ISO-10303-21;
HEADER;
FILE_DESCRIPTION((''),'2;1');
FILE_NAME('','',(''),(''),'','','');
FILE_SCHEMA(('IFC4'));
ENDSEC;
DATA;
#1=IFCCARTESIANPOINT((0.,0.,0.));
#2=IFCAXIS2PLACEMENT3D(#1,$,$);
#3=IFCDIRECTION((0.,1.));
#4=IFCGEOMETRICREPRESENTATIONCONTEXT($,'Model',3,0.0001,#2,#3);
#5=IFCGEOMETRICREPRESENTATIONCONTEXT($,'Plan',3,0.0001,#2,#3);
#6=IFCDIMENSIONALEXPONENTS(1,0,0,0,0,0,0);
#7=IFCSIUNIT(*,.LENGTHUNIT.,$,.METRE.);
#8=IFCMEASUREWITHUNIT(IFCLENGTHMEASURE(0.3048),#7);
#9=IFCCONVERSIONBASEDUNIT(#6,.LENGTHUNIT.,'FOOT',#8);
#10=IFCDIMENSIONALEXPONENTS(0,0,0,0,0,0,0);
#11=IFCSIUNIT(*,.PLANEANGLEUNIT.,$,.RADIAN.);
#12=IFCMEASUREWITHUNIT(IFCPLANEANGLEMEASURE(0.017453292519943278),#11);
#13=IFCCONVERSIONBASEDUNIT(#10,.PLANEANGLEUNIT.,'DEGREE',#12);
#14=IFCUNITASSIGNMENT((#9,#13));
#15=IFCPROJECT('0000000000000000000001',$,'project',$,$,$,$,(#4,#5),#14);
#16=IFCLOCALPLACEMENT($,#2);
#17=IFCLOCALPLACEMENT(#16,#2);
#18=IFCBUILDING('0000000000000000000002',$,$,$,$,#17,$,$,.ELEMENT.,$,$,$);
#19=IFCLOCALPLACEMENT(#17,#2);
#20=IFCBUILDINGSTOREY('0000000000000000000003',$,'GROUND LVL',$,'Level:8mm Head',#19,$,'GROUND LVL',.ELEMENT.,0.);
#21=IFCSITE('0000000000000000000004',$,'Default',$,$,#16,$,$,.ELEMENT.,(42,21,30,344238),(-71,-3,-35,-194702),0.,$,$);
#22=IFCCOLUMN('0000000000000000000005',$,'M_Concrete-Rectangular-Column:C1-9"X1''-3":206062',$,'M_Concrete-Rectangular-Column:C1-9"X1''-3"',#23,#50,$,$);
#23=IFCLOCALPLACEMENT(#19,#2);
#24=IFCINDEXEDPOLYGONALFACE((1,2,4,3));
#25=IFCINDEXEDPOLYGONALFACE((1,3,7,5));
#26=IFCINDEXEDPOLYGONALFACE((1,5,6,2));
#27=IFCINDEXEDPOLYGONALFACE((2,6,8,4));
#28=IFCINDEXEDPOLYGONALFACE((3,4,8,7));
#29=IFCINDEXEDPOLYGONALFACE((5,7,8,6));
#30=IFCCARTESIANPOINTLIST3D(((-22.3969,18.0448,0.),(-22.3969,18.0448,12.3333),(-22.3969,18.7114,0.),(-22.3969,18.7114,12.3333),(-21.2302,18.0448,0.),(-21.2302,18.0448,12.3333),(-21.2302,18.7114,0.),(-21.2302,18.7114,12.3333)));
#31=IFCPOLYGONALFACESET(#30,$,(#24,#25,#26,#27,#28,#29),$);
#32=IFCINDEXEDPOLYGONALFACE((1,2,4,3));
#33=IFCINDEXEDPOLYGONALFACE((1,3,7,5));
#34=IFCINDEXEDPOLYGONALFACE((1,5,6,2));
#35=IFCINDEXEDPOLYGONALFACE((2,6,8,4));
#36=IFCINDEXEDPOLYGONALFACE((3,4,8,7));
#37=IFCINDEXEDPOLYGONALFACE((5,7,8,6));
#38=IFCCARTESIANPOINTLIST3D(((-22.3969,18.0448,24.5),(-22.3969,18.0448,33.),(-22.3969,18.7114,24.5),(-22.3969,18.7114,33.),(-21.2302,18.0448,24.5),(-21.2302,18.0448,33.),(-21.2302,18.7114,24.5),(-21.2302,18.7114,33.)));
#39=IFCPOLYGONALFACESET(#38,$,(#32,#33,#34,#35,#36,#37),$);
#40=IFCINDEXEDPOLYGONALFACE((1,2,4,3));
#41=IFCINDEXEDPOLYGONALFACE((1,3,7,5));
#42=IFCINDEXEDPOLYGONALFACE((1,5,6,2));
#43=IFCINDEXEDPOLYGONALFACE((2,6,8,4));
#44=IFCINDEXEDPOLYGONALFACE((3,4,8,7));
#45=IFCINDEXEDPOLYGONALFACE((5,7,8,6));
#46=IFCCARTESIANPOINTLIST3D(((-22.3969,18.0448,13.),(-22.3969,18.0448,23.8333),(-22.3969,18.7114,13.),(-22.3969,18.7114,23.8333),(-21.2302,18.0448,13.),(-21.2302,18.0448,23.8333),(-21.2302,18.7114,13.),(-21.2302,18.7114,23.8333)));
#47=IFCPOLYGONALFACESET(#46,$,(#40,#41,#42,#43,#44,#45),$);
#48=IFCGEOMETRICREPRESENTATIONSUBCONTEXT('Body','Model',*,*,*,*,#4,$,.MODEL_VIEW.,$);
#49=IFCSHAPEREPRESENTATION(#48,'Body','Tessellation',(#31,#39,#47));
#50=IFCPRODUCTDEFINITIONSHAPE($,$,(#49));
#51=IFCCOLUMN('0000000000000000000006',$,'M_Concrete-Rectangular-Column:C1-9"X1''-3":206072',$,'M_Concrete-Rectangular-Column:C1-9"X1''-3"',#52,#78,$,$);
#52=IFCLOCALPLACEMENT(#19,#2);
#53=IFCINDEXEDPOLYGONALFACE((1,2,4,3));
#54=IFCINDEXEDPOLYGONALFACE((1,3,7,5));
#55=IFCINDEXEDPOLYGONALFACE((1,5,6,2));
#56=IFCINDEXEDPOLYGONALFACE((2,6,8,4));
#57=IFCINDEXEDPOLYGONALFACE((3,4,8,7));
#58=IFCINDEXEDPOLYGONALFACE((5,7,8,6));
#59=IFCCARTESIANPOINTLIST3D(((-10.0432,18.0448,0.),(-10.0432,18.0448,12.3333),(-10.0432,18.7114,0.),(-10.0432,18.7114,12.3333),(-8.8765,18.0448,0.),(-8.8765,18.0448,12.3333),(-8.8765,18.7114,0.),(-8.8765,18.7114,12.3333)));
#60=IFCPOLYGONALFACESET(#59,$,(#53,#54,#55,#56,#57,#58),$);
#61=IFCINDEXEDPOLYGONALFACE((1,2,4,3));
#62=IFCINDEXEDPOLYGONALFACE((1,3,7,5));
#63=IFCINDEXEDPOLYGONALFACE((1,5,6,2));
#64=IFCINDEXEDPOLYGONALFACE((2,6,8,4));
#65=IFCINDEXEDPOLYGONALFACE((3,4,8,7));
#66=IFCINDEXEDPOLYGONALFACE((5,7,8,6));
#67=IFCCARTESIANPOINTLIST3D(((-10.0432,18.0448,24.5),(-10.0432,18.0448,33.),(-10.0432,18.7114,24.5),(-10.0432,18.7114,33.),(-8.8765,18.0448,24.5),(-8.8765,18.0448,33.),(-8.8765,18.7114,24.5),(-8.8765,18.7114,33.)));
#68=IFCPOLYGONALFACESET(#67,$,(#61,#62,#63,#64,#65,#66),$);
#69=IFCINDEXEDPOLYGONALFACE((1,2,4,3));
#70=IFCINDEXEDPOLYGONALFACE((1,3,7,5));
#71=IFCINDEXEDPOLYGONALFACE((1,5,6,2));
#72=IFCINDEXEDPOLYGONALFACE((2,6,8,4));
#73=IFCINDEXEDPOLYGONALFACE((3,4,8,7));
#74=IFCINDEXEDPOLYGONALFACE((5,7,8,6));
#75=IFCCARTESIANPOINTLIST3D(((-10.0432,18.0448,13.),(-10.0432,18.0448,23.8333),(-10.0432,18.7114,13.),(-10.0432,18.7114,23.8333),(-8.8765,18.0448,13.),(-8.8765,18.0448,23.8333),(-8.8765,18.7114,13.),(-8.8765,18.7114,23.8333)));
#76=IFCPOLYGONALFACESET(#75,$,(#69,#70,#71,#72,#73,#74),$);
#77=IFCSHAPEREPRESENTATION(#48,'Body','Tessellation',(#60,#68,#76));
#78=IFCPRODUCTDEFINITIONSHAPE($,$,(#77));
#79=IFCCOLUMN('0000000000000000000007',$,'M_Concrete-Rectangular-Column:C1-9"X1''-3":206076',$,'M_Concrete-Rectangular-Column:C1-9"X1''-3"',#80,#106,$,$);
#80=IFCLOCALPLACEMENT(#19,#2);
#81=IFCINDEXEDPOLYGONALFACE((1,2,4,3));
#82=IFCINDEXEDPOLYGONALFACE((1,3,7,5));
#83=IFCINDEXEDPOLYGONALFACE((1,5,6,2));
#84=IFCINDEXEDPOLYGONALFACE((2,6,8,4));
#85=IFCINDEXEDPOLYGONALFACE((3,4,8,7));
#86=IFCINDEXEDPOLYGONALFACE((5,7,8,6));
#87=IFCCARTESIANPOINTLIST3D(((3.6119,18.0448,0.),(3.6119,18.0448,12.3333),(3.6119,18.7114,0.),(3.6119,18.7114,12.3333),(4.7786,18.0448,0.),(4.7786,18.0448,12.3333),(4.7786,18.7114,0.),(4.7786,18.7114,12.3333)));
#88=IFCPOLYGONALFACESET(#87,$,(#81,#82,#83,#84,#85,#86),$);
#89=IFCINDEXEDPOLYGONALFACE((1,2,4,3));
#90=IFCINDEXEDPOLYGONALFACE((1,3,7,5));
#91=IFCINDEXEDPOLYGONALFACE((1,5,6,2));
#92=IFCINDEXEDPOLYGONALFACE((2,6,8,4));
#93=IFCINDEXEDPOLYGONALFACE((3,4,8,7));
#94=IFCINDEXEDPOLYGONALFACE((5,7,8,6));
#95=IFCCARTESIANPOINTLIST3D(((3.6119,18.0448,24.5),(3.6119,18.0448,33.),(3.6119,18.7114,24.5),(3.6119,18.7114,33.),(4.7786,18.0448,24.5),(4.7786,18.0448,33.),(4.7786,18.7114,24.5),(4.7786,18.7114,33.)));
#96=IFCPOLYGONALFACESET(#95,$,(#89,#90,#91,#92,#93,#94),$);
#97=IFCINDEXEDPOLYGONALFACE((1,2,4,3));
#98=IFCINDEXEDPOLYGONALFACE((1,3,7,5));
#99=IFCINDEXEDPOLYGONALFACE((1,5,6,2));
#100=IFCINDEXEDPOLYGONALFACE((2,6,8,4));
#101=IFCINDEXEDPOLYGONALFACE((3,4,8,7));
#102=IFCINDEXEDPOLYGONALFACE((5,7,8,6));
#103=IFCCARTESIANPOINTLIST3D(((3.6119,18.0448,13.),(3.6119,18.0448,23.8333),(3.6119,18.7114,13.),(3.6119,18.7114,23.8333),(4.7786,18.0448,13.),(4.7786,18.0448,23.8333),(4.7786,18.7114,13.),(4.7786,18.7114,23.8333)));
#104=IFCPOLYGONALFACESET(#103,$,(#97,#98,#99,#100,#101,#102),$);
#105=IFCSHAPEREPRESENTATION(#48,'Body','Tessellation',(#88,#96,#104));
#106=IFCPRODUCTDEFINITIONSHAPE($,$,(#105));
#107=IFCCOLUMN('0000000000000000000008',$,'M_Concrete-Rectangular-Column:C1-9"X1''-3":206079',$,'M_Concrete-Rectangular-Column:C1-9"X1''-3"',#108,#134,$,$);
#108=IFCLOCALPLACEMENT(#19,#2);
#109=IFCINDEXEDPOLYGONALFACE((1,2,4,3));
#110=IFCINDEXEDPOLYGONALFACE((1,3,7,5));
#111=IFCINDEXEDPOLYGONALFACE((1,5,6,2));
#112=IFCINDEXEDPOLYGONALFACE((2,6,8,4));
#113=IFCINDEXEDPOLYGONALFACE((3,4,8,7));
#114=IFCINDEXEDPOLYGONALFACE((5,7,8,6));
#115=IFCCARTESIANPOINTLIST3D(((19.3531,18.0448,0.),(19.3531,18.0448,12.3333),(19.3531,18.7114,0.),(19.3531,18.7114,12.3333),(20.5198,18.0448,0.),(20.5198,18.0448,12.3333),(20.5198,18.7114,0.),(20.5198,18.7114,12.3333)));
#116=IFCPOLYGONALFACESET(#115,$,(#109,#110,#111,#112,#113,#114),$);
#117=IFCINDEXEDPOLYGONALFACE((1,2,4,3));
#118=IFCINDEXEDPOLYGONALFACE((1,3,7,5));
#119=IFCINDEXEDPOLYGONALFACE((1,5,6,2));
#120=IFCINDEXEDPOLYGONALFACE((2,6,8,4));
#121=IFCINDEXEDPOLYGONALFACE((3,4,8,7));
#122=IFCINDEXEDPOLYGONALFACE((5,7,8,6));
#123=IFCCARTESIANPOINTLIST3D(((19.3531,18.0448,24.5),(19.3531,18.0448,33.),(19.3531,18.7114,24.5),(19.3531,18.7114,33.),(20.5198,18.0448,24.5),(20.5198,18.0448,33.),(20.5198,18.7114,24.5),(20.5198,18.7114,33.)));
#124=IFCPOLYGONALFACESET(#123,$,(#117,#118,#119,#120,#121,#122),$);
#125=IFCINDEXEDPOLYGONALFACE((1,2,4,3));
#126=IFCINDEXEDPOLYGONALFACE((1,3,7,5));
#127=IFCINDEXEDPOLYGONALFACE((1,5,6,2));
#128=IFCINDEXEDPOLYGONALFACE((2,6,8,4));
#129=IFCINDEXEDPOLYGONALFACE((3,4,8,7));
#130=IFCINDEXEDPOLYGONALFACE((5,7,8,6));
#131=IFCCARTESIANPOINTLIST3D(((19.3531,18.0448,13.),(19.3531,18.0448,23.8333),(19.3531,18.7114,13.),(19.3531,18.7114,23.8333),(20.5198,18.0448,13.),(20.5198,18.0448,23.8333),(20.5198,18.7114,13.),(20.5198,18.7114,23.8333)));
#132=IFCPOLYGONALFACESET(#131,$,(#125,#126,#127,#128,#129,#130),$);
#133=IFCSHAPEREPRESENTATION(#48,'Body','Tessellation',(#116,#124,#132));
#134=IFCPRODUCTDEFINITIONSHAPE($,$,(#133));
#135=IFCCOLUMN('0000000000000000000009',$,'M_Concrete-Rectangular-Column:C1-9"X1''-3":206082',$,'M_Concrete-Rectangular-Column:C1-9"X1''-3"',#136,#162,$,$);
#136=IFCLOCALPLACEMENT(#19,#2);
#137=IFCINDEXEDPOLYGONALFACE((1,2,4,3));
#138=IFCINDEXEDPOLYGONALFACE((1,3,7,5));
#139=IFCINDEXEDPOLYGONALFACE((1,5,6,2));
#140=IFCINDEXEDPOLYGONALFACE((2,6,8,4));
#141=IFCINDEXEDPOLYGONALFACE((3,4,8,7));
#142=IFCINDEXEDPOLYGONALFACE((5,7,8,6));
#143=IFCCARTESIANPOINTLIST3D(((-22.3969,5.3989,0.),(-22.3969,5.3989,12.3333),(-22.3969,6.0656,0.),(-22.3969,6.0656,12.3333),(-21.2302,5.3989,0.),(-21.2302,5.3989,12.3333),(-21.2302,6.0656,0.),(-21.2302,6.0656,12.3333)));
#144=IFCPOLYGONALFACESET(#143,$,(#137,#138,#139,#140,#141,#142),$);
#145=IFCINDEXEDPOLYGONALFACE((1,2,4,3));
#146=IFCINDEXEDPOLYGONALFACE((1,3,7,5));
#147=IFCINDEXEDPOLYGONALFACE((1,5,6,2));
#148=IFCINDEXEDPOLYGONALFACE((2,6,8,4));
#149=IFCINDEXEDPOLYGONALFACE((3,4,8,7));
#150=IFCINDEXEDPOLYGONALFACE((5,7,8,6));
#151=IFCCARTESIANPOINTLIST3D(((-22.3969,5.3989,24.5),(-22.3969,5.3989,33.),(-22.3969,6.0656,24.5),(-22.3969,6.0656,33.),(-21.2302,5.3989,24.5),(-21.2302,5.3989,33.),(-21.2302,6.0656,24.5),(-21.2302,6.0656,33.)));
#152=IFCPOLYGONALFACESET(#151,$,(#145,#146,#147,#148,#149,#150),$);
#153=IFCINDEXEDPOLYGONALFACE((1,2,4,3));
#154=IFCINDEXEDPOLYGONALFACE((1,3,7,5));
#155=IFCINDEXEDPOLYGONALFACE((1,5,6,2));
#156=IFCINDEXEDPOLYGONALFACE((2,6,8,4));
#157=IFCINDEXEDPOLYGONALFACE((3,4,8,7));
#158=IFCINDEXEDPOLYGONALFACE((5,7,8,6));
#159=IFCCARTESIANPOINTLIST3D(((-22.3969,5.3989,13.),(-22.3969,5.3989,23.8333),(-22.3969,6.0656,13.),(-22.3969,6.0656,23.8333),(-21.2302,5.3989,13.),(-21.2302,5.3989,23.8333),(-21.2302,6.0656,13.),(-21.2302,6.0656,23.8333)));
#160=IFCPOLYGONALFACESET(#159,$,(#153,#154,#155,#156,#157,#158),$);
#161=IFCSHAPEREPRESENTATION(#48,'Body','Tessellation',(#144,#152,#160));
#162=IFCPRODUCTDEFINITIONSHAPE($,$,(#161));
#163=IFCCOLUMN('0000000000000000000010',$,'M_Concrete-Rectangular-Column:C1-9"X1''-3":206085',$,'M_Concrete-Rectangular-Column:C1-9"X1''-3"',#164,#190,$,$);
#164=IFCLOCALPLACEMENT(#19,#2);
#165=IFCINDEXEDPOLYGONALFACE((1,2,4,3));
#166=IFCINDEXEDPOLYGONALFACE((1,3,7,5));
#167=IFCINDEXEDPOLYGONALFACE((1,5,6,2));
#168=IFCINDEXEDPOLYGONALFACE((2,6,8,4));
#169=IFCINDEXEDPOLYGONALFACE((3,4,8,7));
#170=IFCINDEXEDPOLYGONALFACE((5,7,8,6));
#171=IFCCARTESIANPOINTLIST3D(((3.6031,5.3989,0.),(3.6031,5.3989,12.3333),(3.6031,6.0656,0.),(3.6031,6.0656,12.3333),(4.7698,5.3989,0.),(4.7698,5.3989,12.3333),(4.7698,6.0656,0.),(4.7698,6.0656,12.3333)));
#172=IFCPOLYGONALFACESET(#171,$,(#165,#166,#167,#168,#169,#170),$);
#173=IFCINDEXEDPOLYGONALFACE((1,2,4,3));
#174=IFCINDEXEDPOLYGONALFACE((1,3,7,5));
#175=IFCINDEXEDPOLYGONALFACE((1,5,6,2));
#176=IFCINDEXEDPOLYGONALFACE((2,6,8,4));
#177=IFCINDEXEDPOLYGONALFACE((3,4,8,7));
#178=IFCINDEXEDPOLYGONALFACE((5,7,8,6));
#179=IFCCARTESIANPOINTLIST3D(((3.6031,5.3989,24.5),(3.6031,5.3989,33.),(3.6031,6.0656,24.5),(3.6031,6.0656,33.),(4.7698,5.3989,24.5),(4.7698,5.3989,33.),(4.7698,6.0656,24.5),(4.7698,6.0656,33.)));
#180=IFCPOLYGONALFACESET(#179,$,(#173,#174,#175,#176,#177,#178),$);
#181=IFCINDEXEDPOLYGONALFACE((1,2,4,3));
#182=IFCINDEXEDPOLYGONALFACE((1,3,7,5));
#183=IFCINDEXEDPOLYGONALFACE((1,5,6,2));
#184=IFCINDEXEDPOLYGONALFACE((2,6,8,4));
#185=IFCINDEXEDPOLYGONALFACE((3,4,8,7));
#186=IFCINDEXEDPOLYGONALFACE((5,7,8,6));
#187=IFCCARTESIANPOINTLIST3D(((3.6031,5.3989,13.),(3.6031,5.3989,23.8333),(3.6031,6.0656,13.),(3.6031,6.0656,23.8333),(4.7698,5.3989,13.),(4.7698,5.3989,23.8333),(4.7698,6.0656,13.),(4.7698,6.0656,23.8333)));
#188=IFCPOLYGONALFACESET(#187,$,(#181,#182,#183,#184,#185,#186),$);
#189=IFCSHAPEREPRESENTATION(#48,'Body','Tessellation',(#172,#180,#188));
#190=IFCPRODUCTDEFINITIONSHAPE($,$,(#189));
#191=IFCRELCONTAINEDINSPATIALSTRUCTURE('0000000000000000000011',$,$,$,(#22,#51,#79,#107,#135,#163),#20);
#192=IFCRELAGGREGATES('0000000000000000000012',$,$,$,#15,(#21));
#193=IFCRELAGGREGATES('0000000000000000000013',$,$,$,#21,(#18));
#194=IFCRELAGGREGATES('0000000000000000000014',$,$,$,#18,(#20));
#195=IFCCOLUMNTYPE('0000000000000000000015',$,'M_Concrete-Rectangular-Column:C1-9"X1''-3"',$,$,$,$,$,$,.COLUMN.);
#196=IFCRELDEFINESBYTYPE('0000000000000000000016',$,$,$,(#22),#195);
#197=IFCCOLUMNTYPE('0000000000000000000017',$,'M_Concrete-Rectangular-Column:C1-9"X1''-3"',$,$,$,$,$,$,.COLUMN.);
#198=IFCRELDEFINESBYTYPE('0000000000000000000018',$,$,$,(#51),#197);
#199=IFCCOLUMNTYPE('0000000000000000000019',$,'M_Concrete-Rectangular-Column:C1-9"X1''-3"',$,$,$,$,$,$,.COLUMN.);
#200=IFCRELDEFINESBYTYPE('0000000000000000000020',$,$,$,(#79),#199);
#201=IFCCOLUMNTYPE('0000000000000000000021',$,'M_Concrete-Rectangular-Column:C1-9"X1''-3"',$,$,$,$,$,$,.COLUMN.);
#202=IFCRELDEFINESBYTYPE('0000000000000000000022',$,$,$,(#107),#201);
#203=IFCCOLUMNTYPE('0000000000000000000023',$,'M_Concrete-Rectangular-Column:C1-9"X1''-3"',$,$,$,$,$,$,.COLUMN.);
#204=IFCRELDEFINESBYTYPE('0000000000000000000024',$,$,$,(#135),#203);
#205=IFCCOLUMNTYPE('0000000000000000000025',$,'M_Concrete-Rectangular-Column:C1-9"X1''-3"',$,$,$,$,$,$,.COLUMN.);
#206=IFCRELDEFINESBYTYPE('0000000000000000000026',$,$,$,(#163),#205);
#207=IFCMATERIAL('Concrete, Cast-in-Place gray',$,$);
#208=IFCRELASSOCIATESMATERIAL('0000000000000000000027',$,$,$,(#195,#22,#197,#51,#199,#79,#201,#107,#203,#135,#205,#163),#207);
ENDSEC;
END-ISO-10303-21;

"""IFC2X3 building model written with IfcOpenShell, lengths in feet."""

from ifc_helpers import new_model, entity, si_unit, converted_unit, direction, frame, frame_2d, origin, origin_2d_with_axis, place, context, subcontext, project, spatial, rectangle, extrude, source, transform, mapped, material, type_object, type_shapes, element, save


model = new_model("IFC2X3")

# Units and contexts
model_context = context("Model", 3, precision=0.0001, world=origin(), true_north=direction((0.0, 1.0)))
plan_context = context("Plan", 3, precision=0.0001, world=origin(), true_north=direction((0.0, 1.0)))
body_context = subcontext(model_context, "Body", "Model", "MODEL_VIEW")
ifc_project = project(units=[converted_unit("LENGTHUNIT", "FOOT", entity("IfcLengthMeasure", 0.3048), si_unit("LENGTHUNIT", "METRE"), dimensions=[1, 0, 0, 0, 0, 0, 0]), converted_unit("PLANEANGLEUNIT", "DEGREE", entity("IfcPlaneAngleMeasure", 0.017453292519943278), si_unit("PLANEANGLEUNIT", "RADIAN"), dimensions=[0, 0, 0, 0, 0, 0, 0])], contexts=[model_context, plan_context])

# Site, building, storey
site_placement = place(None, origin())
site = spatial("IfcSite", under=ifc_project, at=site_placement, Name="Default", CompositionType="ELEMENT", RefLatitude=(42, 21, 30, 344238), RefLongitude=(-71, -3, -35, -194702), RefElevation=0.0)
building_placement = place(site_placement, origin())
building = spatial("IfcBuilding", under=site, at=building_placement, CompositionType="ELEMENT")
storey_placement = place(building_placement, origin())
storey = spatial("IfcBuildingStorey", under=building, at=storey_placement, Name="GROUND LVL", ObjectType="Level:8mm Head", LongName="GROUND LVL", CompositionType="ELEMENT", Elevation=0.0)

# Columns
ifc_material_1 = material(Name="Concrete, Cast-in-Place gray")
column_type_1 = type_object("IfcColumnType", Name="M_Concrete-Rectangular-Column:C1-9\"X1'-3\"", PredefinedType="COLUMN", material=ifc_material_1)
shared_shape_1 = source(origin(), body_context, "Body", "SweptSolid", [
    extrude(rectangle(XDim=0.6667, YDim=1.1667, at=frame_2d((0.0, 0.0), x_axis=(1.0, 0.0))), frame((-21.8136, 18.3781, 0.0), z_axis=(0.0, 0.0, 1.0), x_axis=(0.0, -1.0, 0.0)), (0.0, 0.0, 1.0), 12.3333),
    extrude(rectangle(XDim=0.6667, YDim=1.1667, at=origin_2d_with_axis()), frame((-21.8136, 18.3781, 24.5), z_axis=(0.0, 0.0, 1.0), x_axis=(0.0, -1.0, 0.0)), (0.0, 0.0, 1.0), 8.5),
    extrude(rectangle(XDim=0.6667, YDim=1.1667, at=origin_2d_with_axis()), frame((-21.8136, 18.3781, 13.0), z_axis=(0.0, 0.0, 1.0), x_axis=(0.0, -1.0, 0.0)), (0.0, 0.0, 1.0), 10.8333),
])
type_shapes(column_type_1, [shared_shape_1])
column_1_placement = place(storey_placement, origin())
element("IfcColumn", 1, at=column_1_placement, inside=storey, type_object=column_type_1, material=ifc_material_1, Name="M_Concrete-Rectangular-Column:C1-9\"X1'-3\":206062", ObjectType="M_Concrete-Rectangular-Column:C1-9\"X1'-3\"", context=body_context, shape_type="MappedRepresentation", body=[
    mapped(shared_shape_1, transform((0.0, 0.0, 0.0), scale=1.0)),
])
column_type_2 = type_object("IfcColumnType", Name="M_Concrete-Rectangular-Column:C1-9\"X1'-3\"", PredefinedType="COLUMN", material=ifc_material_1)
shared_shape_2 = source(origin(), body_context, "Body", "SweptSolid", [
    extrude(rectangle(XDim=0.6667, YDim=1.1667, at=frame_2d((0.0, 0.0), x_axis=(1.0, 0.0))), frame((-9.4598, 18.3781, 0.0), z_axis=(0.0, 0.0, 1.0), x_axis=(0.0, -1.0, 0.0)), (0.0, 0.0, 1.0), 12.3333),
    extrude(rectangle(XDim=0.6667, YDim=1.1667, at=origin_2d_with_axis()), frame((-9.4598, 18.3781, 24.5), z_axis=(0.0, 0.0, 1.0), x_axis=(0.0, -1.0, 0.0)), (0.0, 0.0, 1.0), 8.5),
    extrude(rectangle(XDim=0.6667, YDim=1.1667, at=origin_2d_with_axis()), frame((-9.4598, 18.3781, 13.0), z_axis=(0.0, 0.0, 1.0), x_axis=(0.0, -1.0, 0.0)), (0.0, 0.0, 1.0), 10.8333),
])
type_shapes(column_type_2, [shared_shape_2])
column_2_placement = place(storey_placement, origin())
element("IfcColumn", 2, at=column_2_placement, inside=storey, type_object=column_type_2, material=ifc_material_1, Name="M_Concrete-Rectangular-Column:C1-9\"X1'-3\":206072", ObjectType="M_Concrete-Rectangular-Column:C1-9\"X1'-3\"", context=body_context, shape_type="MappedRepresentation", body=[
    mapped(shared_shape_2, transform((0.0, 0.0, 0.0), scale=1.0)),
])
column_type_3 = type_object("IfcColumnType", Name="M_Concrete-Rectangular-Column:C1-9\"X1'-3\"", PredefinedType="COLUMN", material=ifc_material_1)
shared_shape_3 = source(origin(), body_context, "Body", "SweptSolid", [
    extrude(rectangle(XDim=0.6667, YDim=1.1667, at=frame_2d((0.0, 0.0), x_axis=(1.0, 0.0))), frame((4.1952, 18.3781, 0.0), z_axis=(0.0, 0.0, 1.0), x_axis=(0.0, -1.0, 0.0)), (0.0, 0.0, 1.0), 12.3333),
    extrude(rectangle(XDim=0.6667, YDim=1.1667, at=frame_2d((0.0, 0.0), x_axis=(1.0, 0.0))), frame((4.1952, 18.3781, 24.5), z_axis=(0.0, 0.0, 1.0), x_axis=(0.0, -1.0, 0.0)), (0.0, 0.0, 1.0), 8.5),
    extrude(rectangle(XDim=0.6667, YDim=1.1667, at=frame_2d((0.0, 0.0), x_axis=(1.0, 0.0))), frame((4.1952, 18.3781, 13.0), z_axis=(0.0, 0.0, 1.0), x_axis=(0.0, -1.0, 0.0)), (0.0, 0.0, 1.0), 10.8333),
])
type_shapes(column_type_3, [shared_shape_3])
column_3_placement = place(storey_placement, origin())
element("IfcColumn", 3, at=column_3_placement, inside=storey, type_object=column_type_3, material=ifc_material_1, Name="M_Concrete-Rectangular-Column:C1-9\"X1'-3\":206076", ObjectType="M_Concrete-Rectangular-Column:C1-9\"X1'-3\"", context=body_context, shape_type="MappedRepresentation", body=[
    mapped(shared_shape_3, transform((0.0, 0.0, 0.0), scale=1.0)),
])
column_type_4 = type_object("IfcColumnType", Name="M_Concrete-Rectangular-Column:C1-9\"X1'-3\"", PredefinedType="COLUMN", material=ifc_material_1)
shared_shape_4 = source(origin(), body_context, "Body", "SweptSolid", [
    extrude(rectangle(XDim=0.6667, YDim=1.1667, at=frame_2d((0.0, 0.0), x_axis=(1.0, 0.0))), frame((19.9364, 18.3781, 0.0), z_axis=(0.0, 0.0, 1.0), x_axis=(0.0, -1.0, 0.0)), (0.0, 0.0, 1.0), 12.3333),
    extrude(rectangle(XDim=0.6667, YDim=1.1667, at=origin_2d_with_axis()), frame((19.9364, 18.3781, 24.5), z_axis=(0.0, 0.0, 1.0), x_axis=(0.0, -1.0, 0.0)), (0.0, 0.0, 1.0), 8.5),
    extrude(rectangle(XDim=0.6667, YDim=1.1667, at=origin_2d_with_axis()), frame((19.9364, 18.3781, 13.0), z_axis=(0.0, 0.0, 1.0), x_axis=(0.0, -1.0, 0.0)), (0.0, 0.0, 1.0), 10.8333),
])
type_shapes(column_type_4, [shared_shape_4])
column_4_placement = place(storey_placement, origin())
element("IfcColumn", 4, at=column_4_placement, inside=storey, type_object=column_type_4, material=ifc_material_1, Name="M_Concrete-Rectangular-Column:C1-9\"X1'-3\":206079", ObjectType="M_Concrete-Rectangular-Column:C1-9\"X1'-3\"", context=body_context, shape_type="MappedRepresentation", body=[
    mapped(shared_shape_4, transform((0.0, 0.0, 0.0), scale=1.0)),
])
column_type_5 = type_object("IfcColumnType", Name="M_Concrete-Rectangular-Column:C1-9\"X1'-3\"", PredefinedType="COLUMN", material=ifc_material_1)
shared_shape_5 = source(origin(), body_context, "Body", "SweptSolid", [
    extrude(rectangle(XDim=0.6667, YDim=1.1667, at=frame_2d((0.0, 0.0), x_axis=(1.0, 0.0))), frame((-21.8136, 5.7323, 0.0), z_axis=(0.0, 0.0, 1.0), x_axis=(0.0, -1.0, 0.0)), (0.0, 0.0, 1.0), 12.3333),
    extrude(rectangle(XDim=0.6667, YDim=1.1667, at=frame_2d((0.0, 0.0), x_axis=(1.0, 0.0))), frame((-21.8136, 5.7323, 24.5), z_axis=(0.0, 0.0, 1.0), x_axis=(0.0, -1.0, 0.0)), (0.0, 0.0, 1.0), 8.5),
    extrude(rectangle(XDim=0.6667, YDim=1.1667, at=frame_2d((0.0, 0.0), x_axis=(1.0, 0.0))), frame((-21.8136, 5.7323, 13.0), z_axis=(0.0, 0.0, 1.0), x_axis=(0.0, -1.0, 0.0)), (0.0, 0.0, 1.0), 10.8333),
])
type_shapes(column_type_5, [shared_shape_5])
column_5_placement = place(storey_placement, origin())
element("IfcColumn", 5, at=column_5_placement, inside=storey, type_object=column_type_5, material=ifc_material_1, Name="M_Concrete-Rectangular-Column:C1-9\"X1'-3\":206082", ObjectType="M_Concrete-Rectangular-Column:C1-9\"X1'-3\"", context=body_context, shape_type="MappedRepresentation", body=[
    mapped(shared_shape_5, transform((0.0, 0.0, 0.0), scale=1.0)),
])
column_type_6 = type_object("IfcColumnType", Name="M_Concrete-Rectangular-Column:C1-9\"X1'-3\"", PredefinedType="COLUMN", material=ifc_material_1)
shared_shape_6 = source(origin(), body_context, "Body", "SweptSolid", [
    extrude(rectangle(XDim=0.6667, YDim=1.1667, at=frame_2d((0.0, 0.0), x_axis=(1.0, 0.0))), frame((4.1864, 5.7323, 0.0), z_axis=(0.0, 0.0, 1.0), x_axis=(0.0, -1.0, 0.0)), (0.0, 0.0, 1.0), 12.3333),
    extrude(rectangle(XDim=0.6667, YDim=1.1667, at=frame_2d((0.0, 0.0), x_axis=(1.0, 0.0))), frame((4.1864, 5.7323, 24.5), z_axis=(0.0, 0.0, 1.0), x_axis=(0.0, -1.0, 0.0)), (0.0, 0.0, 1.0), 8.5),
    extrude(rectangle(XDim=0.6667, YDim=1.1667, at=frame_2d((0.0, 0.0), x_axis=(1.0, 0.0))), frame((4.1864, 5.7323, 13.0), z_axis=(0.0, 0.0, 1.0), x_axis=(0.0, -1.0, 0.0)), (0.0, 0.0, 1.0), 10.8333),
])
type_shapes(column_type_6, [shared_shape_6])
column_6_placement = place(storey_placement, origin())
element("IfcColumn", 6, at=column_6_placement, inside=storey, type_object=column_type_6, material=ifc_material_1, Name="M_Concrete-Rectangular-Column:C1-9\"X1'-3\":206085", ObjectType="M_Concrete-Rectangular-Column:C1-9\"X1'-3\"", context=body_context, shape_type="MappedRepresentation", body=[
    mapped(shared_shape_6, transform((0.0, 0.0, 0.0), scale=1.0)),
])

save(model, "model.ifc")
